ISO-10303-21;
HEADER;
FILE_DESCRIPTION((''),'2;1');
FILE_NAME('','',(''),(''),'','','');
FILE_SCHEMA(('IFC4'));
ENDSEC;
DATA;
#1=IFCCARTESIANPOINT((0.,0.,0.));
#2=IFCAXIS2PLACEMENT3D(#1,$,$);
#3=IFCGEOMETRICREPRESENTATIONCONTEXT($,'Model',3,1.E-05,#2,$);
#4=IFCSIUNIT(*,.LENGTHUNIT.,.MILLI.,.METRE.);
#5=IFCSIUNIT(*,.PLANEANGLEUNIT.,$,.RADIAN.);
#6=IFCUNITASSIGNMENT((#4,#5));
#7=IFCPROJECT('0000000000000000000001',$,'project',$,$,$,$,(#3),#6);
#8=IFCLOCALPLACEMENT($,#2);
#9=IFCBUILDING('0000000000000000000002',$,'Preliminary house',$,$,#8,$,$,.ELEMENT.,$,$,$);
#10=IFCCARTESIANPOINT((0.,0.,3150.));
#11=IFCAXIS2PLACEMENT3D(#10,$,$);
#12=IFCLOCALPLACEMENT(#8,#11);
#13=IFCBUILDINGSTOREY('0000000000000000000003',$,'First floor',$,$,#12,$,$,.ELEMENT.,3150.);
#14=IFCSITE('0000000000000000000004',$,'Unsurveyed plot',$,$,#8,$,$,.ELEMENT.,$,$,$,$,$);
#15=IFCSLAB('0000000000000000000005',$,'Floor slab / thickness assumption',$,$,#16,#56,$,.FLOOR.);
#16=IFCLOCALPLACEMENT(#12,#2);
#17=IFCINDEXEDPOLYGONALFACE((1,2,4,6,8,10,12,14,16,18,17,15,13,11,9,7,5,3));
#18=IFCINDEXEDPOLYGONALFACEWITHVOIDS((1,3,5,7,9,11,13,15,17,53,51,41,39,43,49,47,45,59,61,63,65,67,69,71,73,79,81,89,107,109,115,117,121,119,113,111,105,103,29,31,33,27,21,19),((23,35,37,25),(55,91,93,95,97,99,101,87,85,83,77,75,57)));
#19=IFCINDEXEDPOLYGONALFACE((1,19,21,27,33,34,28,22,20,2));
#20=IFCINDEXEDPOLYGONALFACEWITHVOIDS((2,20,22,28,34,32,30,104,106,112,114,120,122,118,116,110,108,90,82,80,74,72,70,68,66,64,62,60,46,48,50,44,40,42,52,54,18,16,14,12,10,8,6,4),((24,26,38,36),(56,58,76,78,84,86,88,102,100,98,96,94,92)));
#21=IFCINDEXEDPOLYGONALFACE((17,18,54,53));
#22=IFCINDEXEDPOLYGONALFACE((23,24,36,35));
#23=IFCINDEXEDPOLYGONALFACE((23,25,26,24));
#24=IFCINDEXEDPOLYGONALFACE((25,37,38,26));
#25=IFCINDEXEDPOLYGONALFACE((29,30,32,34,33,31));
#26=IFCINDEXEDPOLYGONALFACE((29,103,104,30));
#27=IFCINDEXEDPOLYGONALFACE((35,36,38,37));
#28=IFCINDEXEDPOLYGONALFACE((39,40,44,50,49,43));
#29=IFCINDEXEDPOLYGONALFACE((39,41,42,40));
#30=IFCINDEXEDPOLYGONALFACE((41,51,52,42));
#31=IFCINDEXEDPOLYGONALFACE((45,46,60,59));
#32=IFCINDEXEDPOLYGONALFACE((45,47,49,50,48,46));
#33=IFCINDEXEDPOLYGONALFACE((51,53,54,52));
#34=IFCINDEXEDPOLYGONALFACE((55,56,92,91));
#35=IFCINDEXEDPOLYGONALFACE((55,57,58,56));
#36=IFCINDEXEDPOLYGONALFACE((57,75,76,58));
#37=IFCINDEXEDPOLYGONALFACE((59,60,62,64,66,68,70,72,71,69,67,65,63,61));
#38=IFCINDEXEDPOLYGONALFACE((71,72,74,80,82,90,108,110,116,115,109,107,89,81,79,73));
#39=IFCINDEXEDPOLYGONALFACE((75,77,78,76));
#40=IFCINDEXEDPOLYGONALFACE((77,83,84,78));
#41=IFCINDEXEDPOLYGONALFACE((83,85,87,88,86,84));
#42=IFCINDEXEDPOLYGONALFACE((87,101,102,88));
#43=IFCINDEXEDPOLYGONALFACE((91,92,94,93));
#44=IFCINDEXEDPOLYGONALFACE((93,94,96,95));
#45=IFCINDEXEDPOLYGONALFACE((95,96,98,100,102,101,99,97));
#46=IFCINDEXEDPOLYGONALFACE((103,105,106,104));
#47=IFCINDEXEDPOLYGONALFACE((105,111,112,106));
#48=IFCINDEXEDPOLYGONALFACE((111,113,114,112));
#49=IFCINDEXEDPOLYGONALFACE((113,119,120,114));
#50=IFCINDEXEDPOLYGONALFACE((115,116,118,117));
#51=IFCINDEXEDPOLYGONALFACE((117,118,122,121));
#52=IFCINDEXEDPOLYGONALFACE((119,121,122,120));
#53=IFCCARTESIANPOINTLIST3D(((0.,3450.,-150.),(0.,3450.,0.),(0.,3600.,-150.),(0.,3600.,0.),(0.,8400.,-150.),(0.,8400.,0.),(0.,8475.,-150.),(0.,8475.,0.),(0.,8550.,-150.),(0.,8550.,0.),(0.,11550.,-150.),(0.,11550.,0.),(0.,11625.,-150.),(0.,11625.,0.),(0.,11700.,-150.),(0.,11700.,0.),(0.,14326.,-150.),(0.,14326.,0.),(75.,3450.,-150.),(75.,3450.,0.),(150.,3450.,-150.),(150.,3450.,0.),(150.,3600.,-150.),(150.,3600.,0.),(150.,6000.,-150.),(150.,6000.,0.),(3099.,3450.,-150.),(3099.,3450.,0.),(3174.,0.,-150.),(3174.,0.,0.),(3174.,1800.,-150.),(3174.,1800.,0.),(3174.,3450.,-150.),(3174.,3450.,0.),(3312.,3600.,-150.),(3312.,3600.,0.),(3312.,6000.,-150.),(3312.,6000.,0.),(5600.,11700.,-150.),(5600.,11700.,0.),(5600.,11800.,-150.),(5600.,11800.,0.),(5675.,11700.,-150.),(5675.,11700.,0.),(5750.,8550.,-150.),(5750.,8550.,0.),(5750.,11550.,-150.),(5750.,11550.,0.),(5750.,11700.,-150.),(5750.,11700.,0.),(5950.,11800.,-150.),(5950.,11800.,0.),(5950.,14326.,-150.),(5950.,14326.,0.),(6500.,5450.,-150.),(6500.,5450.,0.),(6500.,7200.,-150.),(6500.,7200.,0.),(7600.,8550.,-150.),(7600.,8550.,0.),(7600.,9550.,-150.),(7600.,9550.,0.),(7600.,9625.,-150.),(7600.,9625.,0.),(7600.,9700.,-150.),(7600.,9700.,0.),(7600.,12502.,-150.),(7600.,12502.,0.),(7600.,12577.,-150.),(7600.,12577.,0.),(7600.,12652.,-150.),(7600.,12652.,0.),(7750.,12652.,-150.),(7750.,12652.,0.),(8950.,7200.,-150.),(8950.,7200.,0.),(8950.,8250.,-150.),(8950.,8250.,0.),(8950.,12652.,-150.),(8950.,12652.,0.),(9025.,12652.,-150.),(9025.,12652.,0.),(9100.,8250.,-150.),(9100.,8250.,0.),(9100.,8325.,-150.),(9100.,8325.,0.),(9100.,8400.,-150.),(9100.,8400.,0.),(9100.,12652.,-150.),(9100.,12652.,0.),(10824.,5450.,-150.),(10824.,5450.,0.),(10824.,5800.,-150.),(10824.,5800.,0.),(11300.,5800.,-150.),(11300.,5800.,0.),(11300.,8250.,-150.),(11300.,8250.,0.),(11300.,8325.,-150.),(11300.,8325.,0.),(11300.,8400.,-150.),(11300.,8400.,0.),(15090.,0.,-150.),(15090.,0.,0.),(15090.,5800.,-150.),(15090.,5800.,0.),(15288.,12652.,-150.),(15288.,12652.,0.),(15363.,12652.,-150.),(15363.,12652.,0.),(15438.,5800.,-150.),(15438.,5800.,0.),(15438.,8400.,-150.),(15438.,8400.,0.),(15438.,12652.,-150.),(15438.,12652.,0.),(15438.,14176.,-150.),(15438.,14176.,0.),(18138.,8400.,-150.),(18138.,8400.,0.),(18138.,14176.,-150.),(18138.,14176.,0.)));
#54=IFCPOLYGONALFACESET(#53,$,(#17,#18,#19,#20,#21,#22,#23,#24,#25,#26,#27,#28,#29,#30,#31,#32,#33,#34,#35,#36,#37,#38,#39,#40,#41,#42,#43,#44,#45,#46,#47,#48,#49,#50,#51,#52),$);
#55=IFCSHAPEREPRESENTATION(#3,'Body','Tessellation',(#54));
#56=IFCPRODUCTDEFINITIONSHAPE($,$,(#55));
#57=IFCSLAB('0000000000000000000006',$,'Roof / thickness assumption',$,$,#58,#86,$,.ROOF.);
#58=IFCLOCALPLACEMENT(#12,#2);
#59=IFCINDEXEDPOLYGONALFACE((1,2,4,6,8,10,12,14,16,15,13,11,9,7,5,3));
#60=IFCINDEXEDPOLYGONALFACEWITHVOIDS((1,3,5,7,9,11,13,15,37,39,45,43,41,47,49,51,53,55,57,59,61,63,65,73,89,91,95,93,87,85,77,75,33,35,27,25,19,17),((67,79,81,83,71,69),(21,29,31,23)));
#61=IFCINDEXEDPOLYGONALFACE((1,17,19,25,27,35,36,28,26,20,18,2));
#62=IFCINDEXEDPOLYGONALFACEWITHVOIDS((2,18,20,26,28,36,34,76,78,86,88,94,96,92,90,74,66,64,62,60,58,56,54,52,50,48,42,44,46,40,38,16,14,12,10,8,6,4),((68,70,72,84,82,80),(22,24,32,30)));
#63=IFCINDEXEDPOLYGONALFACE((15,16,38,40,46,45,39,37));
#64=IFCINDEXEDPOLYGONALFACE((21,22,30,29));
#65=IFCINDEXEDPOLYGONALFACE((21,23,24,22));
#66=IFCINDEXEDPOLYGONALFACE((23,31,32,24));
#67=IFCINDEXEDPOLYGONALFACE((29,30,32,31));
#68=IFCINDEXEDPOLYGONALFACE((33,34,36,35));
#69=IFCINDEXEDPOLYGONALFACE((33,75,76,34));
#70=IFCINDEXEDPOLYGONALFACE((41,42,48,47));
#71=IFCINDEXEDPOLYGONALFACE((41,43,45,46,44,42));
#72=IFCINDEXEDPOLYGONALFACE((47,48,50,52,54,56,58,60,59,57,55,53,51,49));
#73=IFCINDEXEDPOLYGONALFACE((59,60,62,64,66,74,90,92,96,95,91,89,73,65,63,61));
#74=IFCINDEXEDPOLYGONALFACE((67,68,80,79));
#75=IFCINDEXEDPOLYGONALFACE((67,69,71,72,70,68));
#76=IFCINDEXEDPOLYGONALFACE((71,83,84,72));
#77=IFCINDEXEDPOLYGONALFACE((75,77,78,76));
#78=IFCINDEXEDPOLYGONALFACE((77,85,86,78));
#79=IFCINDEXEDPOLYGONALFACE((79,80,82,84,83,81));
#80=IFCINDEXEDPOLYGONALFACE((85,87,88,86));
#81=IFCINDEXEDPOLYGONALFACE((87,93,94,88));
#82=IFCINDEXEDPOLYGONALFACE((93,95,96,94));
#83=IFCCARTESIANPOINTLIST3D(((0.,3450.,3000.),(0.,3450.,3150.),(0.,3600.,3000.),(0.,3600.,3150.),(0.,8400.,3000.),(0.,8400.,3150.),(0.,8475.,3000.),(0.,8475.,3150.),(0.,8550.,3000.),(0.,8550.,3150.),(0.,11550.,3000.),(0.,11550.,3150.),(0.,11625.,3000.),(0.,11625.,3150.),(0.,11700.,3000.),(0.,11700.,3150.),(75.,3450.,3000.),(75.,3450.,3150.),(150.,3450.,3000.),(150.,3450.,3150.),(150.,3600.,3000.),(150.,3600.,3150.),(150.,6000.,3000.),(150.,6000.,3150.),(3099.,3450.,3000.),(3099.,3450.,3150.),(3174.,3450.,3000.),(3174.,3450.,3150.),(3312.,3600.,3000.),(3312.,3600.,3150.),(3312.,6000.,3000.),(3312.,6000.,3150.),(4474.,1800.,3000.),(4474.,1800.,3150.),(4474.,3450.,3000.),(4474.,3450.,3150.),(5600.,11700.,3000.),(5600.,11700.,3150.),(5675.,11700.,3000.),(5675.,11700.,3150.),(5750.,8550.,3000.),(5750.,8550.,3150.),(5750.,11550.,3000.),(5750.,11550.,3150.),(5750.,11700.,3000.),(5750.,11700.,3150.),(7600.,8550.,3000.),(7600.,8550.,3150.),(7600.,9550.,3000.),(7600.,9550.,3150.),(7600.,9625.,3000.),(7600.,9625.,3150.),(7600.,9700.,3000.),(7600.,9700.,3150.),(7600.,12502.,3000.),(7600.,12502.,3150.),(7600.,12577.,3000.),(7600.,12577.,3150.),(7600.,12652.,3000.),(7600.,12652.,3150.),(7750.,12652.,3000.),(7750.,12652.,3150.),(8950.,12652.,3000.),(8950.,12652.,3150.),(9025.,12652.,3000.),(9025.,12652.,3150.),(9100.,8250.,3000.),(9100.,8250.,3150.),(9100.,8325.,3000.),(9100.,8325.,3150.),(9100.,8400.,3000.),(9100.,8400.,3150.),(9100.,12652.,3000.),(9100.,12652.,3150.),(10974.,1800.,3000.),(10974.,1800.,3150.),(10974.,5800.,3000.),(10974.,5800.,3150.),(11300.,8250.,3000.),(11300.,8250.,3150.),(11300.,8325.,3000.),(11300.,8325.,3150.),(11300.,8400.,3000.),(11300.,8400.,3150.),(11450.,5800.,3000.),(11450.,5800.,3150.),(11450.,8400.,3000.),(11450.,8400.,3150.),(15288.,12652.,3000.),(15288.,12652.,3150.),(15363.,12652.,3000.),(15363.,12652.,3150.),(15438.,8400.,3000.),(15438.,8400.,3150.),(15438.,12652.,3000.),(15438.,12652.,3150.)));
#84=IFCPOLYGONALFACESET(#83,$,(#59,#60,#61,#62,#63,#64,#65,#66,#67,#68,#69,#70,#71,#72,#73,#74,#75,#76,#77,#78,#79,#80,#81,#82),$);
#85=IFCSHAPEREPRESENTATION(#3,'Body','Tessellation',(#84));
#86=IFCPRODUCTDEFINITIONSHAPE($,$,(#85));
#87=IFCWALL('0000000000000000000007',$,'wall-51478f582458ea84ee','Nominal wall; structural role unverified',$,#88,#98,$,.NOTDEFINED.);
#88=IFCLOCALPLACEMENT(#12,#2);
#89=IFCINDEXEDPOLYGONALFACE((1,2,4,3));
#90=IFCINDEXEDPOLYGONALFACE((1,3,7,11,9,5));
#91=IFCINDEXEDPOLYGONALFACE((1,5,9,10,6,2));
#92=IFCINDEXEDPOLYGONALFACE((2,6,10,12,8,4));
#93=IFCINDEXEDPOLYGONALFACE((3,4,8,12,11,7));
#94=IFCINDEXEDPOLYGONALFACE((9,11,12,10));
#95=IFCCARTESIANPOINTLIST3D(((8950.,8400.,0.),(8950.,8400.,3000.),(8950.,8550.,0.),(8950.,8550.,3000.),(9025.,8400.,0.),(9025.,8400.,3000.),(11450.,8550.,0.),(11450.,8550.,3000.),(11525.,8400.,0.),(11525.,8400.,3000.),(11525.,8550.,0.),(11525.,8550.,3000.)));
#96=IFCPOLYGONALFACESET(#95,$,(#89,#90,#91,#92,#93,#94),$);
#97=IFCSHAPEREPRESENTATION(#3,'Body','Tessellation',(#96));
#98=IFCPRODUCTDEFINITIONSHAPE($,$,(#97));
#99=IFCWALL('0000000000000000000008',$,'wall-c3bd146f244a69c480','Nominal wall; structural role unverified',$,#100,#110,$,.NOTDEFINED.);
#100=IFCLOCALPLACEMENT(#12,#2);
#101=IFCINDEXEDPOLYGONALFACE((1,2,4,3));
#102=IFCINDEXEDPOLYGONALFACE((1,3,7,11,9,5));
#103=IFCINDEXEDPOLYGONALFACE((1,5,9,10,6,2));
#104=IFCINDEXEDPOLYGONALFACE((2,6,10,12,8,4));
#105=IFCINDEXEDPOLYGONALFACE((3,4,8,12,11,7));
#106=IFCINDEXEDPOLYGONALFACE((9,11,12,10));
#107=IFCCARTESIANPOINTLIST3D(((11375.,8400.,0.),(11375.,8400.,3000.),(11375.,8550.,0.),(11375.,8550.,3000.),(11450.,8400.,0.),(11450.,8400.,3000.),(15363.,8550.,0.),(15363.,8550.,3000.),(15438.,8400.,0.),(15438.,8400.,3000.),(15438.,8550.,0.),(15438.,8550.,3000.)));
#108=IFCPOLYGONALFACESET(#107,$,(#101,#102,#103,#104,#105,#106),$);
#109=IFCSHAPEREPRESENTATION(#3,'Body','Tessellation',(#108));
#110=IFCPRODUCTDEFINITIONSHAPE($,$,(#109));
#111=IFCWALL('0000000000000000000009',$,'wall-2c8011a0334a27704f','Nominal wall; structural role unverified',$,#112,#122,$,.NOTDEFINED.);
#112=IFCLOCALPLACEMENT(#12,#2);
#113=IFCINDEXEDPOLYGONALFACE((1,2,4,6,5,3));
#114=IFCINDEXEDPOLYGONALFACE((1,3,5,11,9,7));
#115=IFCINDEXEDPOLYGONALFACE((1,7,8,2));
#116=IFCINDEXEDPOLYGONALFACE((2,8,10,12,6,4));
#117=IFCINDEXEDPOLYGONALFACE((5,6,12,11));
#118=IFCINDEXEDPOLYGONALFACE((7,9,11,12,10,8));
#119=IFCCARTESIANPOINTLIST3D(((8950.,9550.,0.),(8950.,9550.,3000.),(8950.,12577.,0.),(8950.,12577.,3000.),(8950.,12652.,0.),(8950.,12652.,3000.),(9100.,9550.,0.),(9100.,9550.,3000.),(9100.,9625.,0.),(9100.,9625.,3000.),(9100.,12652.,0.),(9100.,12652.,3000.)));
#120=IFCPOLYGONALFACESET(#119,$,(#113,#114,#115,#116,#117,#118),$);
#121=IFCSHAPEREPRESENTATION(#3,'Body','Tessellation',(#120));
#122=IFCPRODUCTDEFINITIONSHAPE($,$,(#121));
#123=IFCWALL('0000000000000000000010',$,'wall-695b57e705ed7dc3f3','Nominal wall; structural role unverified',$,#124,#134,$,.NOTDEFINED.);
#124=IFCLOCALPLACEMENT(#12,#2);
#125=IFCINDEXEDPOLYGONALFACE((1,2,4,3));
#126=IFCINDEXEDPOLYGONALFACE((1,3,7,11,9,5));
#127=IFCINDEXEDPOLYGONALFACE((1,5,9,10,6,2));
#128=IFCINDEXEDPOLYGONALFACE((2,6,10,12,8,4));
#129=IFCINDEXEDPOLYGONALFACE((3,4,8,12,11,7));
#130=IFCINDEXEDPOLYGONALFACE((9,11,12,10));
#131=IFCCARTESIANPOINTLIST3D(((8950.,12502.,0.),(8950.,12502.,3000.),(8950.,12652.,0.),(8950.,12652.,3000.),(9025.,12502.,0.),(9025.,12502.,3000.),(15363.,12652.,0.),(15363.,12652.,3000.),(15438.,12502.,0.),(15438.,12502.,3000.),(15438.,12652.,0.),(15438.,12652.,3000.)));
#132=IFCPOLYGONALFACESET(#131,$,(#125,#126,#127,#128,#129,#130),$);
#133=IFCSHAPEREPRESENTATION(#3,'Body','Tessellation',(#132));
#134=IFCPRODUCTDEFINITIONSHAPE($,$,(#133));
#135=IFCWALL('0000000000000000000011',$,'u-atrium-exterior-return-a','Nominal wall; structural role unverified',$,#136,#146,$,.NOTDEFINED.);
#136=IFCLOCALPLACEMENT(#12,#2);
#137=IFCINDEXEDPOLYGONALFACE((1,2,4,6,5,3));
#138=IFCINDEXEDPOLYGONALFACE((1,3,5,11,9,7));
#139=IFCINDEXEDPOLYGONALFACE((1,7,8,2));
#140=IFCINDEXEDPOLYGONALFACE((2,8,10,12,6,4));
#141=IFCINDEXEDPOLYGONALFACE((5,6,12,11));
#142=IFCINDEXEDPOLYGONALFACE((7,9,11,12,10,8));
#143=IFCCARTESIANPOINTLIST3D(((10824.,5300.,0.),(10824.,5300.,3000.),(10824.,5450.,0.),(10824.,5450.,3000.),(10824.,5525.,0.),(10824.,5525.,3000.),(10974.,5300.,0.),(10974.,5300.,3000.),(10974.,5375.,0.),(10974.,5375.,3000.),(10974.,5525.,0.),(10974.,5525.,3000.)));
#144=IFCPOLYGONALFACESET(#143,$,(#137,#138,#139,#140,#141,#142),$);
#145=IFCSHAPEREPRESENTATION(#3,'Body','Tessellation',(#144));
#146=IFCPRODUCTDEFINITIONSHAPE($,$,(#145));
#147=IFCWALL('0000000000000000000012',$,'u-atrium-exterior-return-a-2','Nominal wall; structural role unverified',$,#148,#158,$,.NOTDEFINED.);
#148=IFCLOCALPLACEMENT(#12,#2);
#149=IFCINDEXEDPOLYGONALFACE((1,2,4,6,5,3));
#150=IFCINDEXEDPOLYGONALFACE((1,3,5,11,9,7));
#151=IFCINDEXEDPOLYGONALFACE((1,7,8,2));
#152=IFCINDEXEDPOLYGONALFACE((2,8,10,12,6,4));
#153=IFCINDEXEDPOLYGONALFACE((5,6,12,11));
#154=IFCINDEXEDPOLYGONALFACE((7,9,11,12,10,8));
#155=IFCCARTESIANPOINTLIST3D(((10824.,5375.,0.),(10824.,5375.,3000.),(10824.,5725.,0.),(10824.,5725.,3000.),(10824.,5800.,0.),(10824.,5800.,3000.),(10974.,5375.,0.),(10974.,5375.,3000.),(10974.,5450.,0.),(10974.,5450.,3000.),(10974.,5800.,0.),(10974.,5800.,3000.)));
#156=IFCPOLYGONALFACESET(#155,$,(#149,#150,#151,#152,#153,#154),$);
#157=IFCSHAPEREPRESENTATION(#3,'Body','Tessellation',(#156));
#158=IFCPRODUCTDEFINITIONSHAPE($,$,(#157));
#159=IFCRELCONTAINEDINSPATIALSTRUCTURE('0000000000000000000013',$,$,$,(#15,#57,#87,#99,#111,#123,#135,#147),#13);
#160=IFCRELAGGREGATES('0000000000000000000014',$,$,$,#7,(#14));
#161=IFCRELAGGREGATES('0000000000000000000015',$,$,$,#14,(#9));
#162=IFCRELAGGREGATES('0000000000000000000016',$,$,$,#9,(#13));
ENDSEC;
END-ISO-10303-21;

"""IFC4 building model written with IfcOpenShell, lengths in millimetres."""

from ifc_helpers import new_model, si_unit, frame, origin, place, context, project, spatial, polyline, outline, extrude, element, save


model = new_model("IFC4")

# Units and contexts
model_context = context("Model", 3, precision=1e-05, world=origin())
ifc_project = project(units=[si_unit("LENGTHUNIT", "METRE", prefix="MILLI"), si_unit("PLANEANGLEUNIT", "RADIAN")], contexts=[model_context])

# Site, building, storey
placement_1 = place(None, origin())
site = spatial("IfcSite", under=ifc_project, at=placement_1, Name="Unsurveyed plot", CompositionType="ELEMENT")
building = spatial("IfcBuilding", under=site, at=placement_1, Name="Preliminary house", CompositionType="ELEMENT")
placement_2 = place(placement_1, frame((0.0, 0.0, 3150.0)))
storey = spatial("IfcBuildingStorey", under=building, at=placement_2, Name="First floor", CompositionType="ELEMENT", Elevation=3150.0)

# Slabs
element("IfcSlab", 1, at=placement_2, inside=storey, Name="Floor slab / thickness assumption", PredefinedType="FLOOR", context=model_context, shape_type="SweptSolid", body=[
    extrude(outline(polyline([(0.0, 3450.0), (0.0, 3600.0), (0.0, 8400.0), (0.0, 8475.0), (0.0, 8550.0), (0.0, 11550.0), (0.0, 11625.0), (0.0, 11700.0), (0.0, 14326.0), (5950.0, 14326.0), (5950.0, 11800.0), (5600.0, 11800.0), (5600.0, 11700.0), (5675.0, 11700.0), (5750.0, 11700.0), (5750.0, 11550.0), (5750.0, 8550.0), (7600.0, 8550.0), (7600.0, 9550.0), (7600.0, 9625.0), (7600.0, 9700.0), (7600.0, 12502.0), (7600.0, 12577.0), (7600.0, 12652.0), (7750.0, 12652.0), (8950.0, 12652.0), (9025.0, 12652.0), (9100.0, 12652.0), (15288.0, 12652.0), (15363.0, 12652.0), (15438.0, 12652.0), (15438.0, 14176.0), (18138.0, 14176.0), (18138.0, 8400.0), (15438.0, 8400.0), (15438.0, 5800.0), (15090.0, 5800.0), (15090.0, 0.0), (3174.0, 0.0), (3174.0, 1800.0), (3174.0, 3450.0), (3099.0, 3450.0), (150.0, 3450.0), (75.0, 3450.0), (0.0, 3450.0)]), holes=[polyline([(9100.0, 8400.0), (9100.0, 8325.0), (9100.0, 8250.0), (8950.0, 8250.0), (8950.0, 7200.0), (6500.0, 7200.0), (6500.0, 5450.0), (10824.0, 5450.0), (10824.0, 5800.0), (11300.0, 5800.0), (11300.0, 8250.0), (11300.0, 8325.0), (11300.0, 8400.0), (9100.0, 8400.0)]), polyline([(150.0, 6000.0), (150.0, 3600.0), (3312.0, 3600.0), (3312.0, 6000.0), (150.0, 6000.0)])]), frame((0.0, 0.0, -150.0)), (0.0, 0.0, 1.0), 150.0),
])
element("IfcSlab", 2, at=placement_2, inside=storey, Name="Roof / thickness assumption", PredefinedType="ROOF", context=model_context, shape_type="SweptSolid", body=[
    extrude(outline(polyline([(0.0, 8550.0), (0.0, 11550.0), (0.0, 11625.0), (0.0, 11700.0), (5600.0, 11700.0), (5675.0, 11700.0), (5750.0, 11700.0), (5750.0, 11550.0), (5750.0, 8550.0), (7600.0, 8550.0), (7600.0, 9550.0), (7600.0, 9625.0), (7600.0, 9700.0), (7600.0, 12502.0), (7600.0, 12577.0), (7600.0, 12652.0), (7750.0, 12652.0), (8950.0, 12652.0), (9025.0, 12652.0), (9100.0, 12652.0), (15288.0, 12652.0), (15363.0, 12652.0), (15438.0, 12652.0), (15438.0, 8400.0), (11450.0, 8400.0), (11450.0, 5800.0), (10974.0, 5800.0), (10974.0, 1800.0), (4474.0, 1800.0), (4474.0, 3450.0), (3174.0, 3450.0), (3099.0, 3450.0), (150.0, 3450.0), (75.0, 3450.0), (0.0, 3450.0), (0.0, 3600.0), (0.0, 8400.0), (0.0, 8475.0), (0.0, 8550.0)]), holes=[polyline([(11300.0, 8325.0), (11300.0, 8400.0), (9100.0, 8400.0), (9100.0, 8325.0), (9100.0, 8250.0), (11300.0, 8250.0), (11300.0, 8325.0)]), polyline([(150.0, 6000.0), (150.0, 3600.0), (3312.0, 3600.0), (3312.0, 6000.0), (150.0, 6000.0)])]), frame((0.0, 0.0, 3000.0)), (0.0, 0.0, 1.0), 150.0),
])

# Walls
element("IfcWall", 3, at=placement_2, inside=storey, Name="wall-51478f582458ea84ee", Description="Nominal wall; structural role unverified", PredefinedType="NOTDEFINED", context=model_context, shape_type="SweptSolid", body=[
    extrude(outline(polyline([(11450.0, 8550.0), (11525.0, 8550.0), (11525.0, 8400.0), (9025.0, 8400.0), (8950.0, 8400.0), (8950.0, 8550.0), (11450.0, 8550.0)])), origin(), (0.0, 0.0, 1.0), 3000.0),
])
element("IfcWall", 4, at=placement_2, inside=storey, Name="wall-c3bd146f244a69c480", Description="Nominal wall; structural role unverified", PredefinedType="NOTDEFINED", context=model_context, shape_type="SweptSolid", body=[
    extrude(outline(polyline([(15363.0, 8550.0), (15438.0, 8550.0), (15438.0, 8400.0), (11450.0, 8400.0), (11375.0, 8400.0), (11375.0, 8550.0), (15363.0, 8550.0)])), origin(), (0.0, 0.0, 1.0), 3000.0),
])
element("IfcWall", 5, at=placement_2, inside=storey, Name="wall-2c8011a0334a27704f", Description="Nominal wall; structural role unverified", PredefinedType="NOTDEFINED", context=model_context, shape_type="SweptSolid", body=[
    extrude(outline(polyline([(8950.0, 12577.0), (8950.0, 12652.0), (9100.0, 12652.0), (9100.0, 9625.0), (9100.0, 9550.0), (8950.0, 9550.0), (8950.0, 12577.0)])), origin(), (0.0, 0.0, 1.0), 3000.0),
])
element("IfcWall", 6, at=placement_2, inside=storey, Name="wall-695b57e705ed7dc3f3", Description="Nominal wall; structural role unverified", PredefinedType="NOTDEFINED", context=model_context, shape_type="SweptSolid", body=[
    extrude(outline(polyline([(15363.0, 12652.0), (15438.0, 12652.0), (15438.0, 12502.0), (9025.0, 12502.0), (8950.0, 12502.0), (8950.0, 12652.0), (15363.0, 12652.0)])), origin(), (0.0, 0.0, 1.0), 3000.0),
])

# Walls
element("IfcWall", 7, at=placement_2, inside=storey, Name="u-atrium-exterior-return-a", Description="Nominal wall; structural role unverified", PredefinedType="NOTDEFINED", context=model_context, shape_type="SweptSolid", body=[
    extrude(outline(polyline([(10824.0, 5450.0), (10824.0, 5525.0), (10974.0, 5525.0), (10974.0, 5375.0), (10974.0, 5300.0), (10824.0, 5300.0), (10824.0, 5450.0)])), origin(), (0.0, 0.0, 1.0), 3000.0),
])
element("IfcWall", 8, at=placement_2, inside=storey, Name="u-atrium-exterior-return-a-2", Description="Nominal wall; structural role unverified", PredefinedType="NOTDEFINED", context=model_context, shape_type="SweptSolid", body=[
    extrude(outline(polyline([(10824.0, 5725.0), (10824.0, 5800.0), (10974.0, 5800.0), (10974.0, 5450.0), (10974.0, 5375.0), (10824.0, 5375.0), (10824.0, 5725.0)])), origin(), (0.0, 0.0, 1.0), 3000.0),
])

save(model, "model.ifc")
